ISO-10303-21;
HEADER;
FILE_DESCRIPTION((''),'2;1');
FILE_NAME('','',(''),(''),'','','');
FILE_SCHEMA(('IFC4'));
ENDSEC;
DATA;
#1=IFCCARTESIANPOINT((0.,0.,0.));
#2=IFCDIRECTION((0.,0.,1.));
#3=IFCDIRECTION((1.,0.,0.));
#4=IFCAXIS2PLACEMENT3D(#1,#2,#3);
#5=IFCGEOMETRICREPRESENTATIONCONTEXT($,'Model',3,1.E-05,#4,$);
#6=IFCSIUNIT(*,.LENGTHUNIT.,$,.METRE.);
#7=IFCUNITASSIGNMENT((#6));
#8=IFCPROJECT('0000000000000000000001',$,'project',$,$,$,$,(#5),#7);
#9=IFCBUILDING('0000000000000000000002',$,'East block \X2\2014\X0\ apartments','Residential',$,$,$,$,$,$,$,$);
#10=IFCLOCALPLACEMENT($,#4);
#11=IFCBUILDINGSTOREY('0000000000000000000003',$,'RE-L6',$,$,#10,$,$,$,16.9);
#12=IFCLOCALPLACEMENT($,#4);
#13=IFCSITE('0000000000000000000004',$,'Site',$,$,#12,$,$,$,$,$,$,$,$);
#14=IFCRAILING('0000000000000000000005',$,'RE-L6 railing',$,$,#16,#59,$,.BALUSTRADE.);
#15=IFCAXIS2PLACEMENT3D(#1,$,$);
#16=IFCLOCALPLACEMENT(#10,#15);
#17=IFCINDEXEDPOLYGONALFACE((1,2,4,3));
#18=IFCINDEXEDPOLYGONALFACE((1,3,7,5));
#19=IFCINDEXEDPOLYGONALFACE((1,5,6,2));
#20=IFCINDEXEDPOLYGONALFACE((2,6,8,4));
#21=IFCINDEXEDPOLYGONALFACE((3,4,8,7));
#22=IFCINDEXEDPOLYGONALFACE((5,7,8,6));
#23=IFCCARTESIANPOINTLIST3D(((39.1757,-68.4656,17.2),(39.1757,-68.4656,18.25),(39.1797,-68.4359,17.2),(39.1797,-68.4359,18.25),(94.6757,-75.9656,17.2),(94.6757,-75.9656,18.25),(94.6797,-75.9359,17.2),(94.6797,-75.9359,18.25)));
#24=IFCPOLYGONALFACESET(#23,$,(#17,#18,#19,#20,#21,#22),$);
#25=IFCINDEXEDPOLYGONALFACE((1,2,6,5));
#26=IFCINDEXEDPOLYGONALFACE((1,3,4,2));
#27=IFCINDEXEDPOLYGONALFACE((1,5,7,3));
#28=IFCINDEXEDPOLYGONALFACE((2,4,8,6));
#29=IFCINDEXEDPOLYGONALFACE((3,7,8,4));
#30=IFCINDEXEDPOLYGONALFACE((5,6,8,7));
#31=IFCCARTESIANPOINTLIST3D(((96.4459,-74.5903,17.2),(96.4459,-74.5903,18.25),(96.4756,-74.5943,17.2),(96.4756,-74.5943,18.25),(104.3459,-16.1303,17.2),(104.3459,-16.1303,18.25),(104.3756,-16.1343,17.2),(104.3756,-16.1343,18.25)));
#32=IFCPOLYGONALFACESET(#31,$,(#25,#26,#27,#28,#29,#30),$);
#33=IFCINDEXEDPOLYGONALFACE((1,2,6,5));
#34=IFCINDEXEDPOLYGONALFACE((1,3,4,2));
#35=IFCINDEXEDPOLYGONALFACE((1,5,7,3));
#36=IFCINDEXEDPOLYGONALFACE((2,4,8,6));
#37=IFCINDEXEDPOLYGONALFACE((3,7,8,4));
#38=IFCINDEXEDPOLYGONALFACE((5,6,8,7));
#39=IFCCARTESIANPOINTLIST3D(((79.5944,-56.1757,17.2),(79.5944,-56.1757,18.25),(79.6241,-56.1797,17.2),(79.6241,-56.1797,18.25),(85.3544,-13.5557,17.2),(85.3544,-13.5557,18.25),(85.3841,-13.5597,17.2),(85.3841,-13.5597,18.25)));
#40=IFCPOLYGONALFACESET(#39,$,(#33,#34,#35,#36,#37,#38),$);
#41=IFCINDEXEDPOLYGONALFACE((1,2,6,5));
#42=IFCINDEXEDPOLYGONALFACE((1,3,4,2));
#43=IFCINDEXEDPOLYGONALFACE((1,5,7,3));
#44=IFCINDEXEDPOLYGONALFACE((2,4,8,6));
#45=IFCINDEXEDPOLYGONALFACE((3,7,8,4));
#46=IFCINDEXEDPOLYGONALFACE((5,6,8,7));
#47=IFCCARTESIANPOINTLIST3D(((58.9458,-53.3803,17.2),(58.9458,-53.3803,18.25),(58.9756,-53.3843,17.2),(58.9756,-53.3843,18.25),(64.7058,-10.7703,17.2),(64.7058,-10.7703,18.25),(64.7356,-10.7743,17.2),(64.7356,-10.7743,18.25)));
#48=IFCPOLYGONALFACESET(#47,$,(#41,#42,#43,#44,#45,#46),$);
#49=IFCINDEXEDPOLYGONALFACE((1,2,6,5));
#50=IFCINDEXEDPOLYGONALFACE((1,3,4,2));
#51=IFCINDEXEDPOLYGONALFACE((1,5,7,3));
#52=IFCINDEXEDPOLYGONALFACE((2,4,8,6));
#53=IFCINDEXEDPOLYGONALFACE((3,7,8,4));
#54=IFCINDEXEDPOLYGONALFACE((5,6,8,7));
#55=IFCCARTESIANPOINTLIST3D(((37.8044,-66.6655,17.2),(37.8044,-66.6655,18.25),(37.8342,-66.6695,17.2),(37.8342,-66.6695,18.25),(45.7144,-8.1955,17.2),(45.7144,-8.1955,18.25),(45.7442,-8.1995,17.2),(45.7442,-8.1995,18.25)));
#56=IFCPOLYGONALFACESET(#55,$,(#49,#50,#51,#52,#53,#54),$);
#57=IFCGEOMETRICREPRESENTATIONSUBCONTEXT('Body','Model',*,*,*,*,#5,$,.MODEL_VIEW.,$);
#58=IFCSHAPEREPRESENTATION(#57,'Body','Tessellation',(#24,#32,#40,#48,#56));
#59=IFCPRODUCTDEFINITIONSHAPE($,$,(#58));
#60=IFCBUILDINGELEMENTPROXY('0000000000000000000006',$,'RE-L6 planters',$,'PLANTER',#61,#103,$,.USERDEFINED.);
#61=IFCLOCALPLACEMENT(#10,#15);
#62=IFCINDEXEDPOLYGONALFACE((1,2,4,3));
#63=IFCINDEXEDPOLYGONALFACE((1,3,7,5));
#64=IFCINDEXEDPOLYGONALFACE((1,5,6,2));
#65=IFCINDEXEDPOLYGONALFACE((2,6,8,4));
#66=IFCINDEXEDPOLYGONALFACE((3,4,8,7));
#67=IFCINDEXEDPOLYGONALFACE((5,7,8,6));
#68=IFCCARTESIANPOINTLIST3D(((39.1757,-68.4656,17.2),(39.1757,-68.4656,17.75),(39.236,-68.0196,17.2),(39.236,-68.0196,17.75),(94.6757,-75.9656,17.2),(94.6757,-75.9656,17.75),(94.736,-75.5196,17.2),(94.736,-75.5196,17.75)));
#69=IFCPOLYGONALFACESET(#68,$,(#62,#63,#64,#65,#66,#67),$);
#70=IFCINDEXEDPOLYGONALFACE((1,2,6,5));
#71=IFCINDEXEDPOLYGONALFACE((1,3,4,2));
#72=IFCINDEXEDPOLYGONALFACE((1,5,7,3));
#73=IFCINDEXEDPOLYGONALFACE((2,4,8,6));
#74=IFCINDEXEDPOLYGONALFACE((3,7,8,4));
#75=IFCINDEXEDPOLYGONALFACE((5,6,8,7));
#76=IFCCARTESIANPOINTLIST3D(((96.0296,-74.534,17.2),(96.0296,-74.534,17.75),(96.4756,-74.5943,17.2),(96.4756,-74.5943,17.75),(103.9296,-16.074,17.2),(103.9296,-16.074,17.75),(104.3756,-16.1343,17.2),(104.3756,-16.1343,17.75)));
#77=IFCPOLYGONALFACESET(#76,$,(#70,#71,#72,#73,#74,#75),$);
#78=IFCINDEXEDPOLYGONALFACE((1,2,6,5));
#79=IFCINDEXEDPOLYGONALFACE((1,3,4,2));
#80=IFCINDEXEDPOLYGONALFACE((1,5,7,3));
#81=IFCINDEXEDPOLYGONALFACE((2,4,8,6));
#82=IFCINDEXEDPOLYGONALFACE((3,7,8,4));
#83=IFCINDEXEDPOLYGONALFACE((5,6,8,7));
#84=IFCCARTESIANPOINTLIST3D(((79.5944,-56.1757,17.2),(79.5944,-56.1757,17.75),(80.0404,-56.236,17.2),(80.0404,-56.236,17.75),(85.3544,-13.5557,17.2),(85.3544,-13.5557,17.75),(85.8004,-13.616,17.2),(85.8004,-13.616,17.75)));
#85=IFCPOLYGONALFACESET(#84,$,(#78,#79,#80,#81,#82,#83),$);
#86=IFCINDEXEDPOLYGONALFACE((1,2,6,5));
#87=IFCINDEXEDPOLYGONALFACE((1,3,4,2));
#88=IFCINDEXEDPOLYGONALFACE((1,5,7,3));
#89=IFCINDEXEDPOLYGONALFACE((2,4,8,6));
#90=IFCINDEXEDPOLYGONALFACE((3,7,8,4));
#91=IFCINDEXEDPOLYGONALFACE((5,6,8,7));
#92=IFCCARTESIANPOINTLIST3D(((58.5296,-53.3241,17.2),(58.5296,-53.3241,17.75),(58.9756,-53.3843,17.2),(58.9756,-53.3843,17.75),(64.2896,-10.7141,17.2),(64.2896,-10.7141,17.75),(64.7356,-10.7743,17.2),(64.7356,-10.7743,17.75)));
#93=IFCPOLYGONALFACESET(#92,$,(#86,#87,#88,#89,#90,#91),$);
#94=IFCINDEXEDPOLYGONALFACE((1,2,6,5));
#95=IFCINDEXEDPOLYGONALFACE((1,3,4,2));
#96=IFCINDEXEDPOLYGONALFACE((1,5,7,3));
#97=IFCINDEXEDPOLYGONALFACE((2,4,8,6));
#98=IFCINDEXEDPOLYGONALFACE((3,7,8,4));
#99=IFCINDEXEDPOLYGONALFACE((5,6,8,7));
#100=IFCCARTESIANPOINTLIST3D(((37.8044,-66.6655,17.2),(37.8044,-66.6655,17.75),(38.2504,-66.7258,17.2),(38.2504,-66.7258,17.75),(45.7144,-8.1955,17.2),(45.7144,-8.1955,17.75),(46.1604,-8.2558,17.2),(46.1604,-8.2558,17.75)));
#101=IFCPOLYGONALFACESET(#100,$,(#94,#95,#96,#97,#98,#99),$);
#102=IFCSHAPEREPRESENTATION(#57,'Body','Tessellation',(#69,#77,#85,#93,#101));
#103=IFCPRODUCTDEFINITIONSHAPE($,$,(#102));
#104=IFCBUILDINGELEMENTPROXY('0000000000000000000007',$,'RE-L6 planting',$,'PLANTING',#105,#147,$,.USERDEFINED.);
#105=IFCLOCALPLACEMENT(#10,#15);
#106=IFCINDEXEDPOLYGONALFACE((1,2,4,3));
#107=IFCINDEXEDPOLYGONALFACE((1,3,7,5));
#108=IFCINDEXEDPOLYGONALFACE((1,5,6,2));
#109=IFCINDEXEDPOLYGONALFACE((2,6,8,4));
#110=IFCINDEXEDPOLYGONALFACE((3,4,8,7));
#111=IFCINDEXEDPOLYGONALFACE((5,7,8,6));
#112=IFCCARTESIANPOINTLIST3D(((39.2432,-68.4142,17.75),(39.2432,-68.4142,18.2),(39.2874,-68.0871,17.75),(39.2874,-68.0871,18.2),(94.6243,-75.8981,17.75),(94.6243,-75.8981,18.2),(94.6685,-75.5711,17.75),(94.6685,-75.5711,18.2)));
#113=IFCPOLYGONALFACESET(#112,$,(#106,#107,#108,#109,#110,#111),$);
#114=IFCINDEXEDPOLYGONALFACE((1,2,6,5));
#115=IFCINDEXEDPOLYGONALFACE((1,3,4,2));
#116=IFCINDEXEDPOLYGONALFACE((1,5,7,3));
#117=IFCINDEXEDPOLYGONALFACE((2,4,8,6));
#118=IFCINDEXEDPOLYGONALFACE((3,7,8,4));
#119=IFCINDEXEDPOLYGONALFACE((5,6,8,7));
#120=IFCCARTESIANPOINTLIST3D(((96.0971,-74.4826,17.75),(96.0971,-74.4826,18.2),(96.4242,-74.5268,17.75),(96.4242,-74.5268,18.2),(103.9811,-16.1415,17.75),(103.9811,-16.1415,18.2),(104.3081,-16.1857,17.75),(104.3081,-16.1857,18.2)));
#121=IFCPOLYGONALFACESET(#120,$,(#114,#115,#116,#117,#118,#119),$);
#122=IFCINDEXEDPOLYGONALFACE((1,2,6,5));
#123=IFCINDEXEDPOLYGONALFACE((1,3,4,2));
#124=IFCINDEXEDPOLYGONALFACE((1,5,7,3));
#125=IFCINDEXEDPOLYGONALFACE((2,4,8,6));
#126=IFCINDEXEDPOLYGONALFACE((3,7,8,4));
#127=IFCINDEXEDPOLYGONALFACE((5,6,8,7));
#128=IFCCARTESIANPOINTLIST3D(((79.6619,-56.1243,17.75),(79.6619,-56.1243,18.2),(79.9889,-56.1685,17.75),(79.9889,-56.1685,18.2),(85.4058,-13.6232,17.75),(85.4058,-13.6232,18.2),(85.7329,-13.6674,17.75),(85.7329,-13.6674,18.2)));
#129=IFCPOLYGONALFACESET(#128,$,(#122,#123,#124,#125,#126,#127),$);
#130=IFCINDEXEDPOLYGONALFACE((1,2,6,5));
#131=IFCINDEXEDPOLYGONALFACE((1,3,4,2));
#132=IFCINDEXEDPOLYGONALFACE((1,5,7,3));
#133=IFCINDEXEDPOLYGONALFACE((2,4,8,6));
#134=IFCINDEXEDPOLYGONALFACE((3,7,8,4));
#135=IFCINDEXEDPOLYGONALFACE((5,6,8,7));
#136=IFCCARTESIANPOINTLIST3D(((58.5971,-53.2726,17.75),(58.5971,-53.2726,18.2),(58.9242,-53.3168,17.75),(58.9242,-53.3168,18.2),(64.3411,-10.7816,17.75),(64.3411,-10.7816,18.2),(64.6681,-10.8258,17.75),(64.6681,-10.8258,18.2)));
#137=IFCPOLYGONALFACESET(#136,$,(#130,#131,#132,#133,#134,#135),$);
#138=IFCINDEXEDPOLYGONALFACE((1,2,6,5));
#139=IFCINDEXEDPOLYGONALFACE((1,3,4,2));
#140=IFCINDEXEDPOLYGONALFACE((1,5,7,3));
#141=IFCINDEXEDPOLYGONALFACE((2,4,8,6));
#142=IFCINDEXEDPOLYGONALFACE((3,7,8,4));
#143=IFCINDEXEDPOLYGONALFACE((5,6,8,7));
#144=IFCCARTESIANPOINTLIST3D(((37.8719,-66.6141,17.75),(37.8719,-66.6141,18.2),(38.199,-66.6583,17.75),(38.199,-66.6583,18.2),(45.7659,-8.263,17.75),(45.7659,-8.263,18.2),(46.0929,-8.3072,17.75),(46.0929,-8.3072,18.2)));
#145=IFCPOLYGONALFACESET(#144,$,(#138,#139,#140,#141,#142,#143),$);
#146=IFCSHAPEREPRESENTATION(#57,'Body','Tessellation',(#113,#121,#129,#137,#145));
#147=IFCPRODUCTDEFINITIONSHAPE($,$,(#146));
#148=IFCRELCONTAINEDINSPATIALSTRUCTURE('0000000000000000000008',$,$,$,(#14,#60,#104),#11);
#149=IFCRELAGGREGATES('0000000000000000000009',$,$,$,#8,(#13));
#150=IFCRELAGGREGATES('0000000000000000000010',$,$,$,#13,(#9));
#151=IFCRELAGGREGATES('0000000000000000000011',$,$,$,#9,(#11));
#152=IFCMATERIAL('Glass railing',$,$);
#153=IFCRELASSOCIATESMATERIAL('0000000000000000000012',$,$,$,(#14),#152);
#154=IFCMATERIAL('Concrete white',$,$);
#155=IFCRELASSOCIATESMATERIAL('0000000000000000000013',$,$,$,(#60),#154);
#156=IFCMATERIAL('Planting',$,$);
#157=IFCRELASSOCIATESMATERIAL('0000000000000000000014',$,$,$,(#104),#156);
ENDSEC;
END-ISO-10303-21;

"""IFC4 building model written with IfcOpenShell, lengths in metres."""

from ifc_helpers import new_model, si_unit, frame, origin_with_axes, place, context, subcontext, project, spatial, polyline, outline, extrude, material, element, save


model = new_model("IFC4")

# Units and contexts
model_context = context("Model", 3, precision=1e-05, world=origin_with_axes())
body_context = subcontext(model_context, "Body", "Model", "MODEL_VIEW")
ifc_project = project(units=[si_unit("LENGTHUNIT", "METRE")], contexts=[model_context])

# Site, building, storey
site_placement = place(None, origin_with_axes())
site = spatial("IfcSite", under=ifc_project, at=site_placement, Name="Site")
building = spatial("IfcBuilding", under=site, Name="East block — apartments", Description="Residential")
storey_placement = place(None, origin_with_axes())
storey = spatial("IfcBuildingStorey", under=building, at=storey_placement, Name="RE-L6", Elevation=16.9)

# Railing
ifc_material_1 = material(Name="Glass railing")
railing_placement = place(storey_placement, origin_with_axes())
element("IfcRailing", 1, at=railing_placement, inside=storey, material=ifc_material_1, Name="RE-L6 railing", PredefinedType="BALUSTRADE", context=body_context, shape_type="SweptSolid", body=[
    extrude(outline(polyline([(39.1757, -68.4656), (94.6757, -75.9656), (94.6797, -75.9359), (39.1797, -68.4359), (39.1757, -68.4656)])), frame((0.0, 0.0, 17.2), z_axis=(0.0, 0.0, 1.0), x_axis=(1.0, 0.0, 0.0)), (0.0, 0.0, 1.0), 1.05),
    extrude(outline(polyline([(96.4756, -74.5943), (104.3756, -16.1343), (104.3459, -16.1303), (96.4459, -74.5903), (96.4756, -74.5943)])), frame((0.0, 0.0, 17.2), z_axis=(0.0, 0.0, 1.0), x_axis=(1.0, 0.0, 0.0)), (0.0, 0.0, 1.0), 1.05),
    extrude(outline(polyline([(85.3544, -13.5557), (79.5944, -56.1757), (79.6241, -56.1797), (85.3841, -13.5597), (85.3544, -13.5557)])), frame((0.0, 0.0, 17.2), z_axis=(0.0, 0.0, 1.0), x_axis=(1.0, 0.0, 0.0)), (0.0, 0.0, 1.0), 1.05),
    extrude(outline(polyline([(58.9756, -53.3843), (64.7356, -10.7743), (64.7058, -10.7703), (58.9458, -53.3803), (58.9756, -53.3843)])), frame((0.0, 0.0, 17.2), z_axis=(0.0, 0.0, 1.0), x_axis=(1.0, 0.0, 0.0)), (0.0, 0.0, 1.0), 1.05),
    extrude(outline(polyline([(45.7144, -8.1955), (37.8044, -66.6655), (37.8342, -66.6695), (45.7442, -8.1995), (45.7144, -8.1955)])), frame((0.0, 0.0, 17.2), z_axis=(0.0, 0.0, 1.0), x_axis=(1.0, 0.0, 0.0)), (0.0, 0.0, 1.0), 1.05),
])

# Building element proxies
ifc_material_2 = material(Name="Concrete white")
proxy_1_placement = place(storey_placement, origin_with_axes())
element("IfcBuildingElementProxy", 2, at=proxy_1_placement, inside=storey, material=ifc_material_2, Name="RE-L6 planters", ObjectType="PLANTER", PredefinedType="USERDEFINED", context=body_context, shape_type="SweptSolid", body=[
    extrude(outline(polyline([(39.1757, -68.4656), (94.6757, -75.9656), (94.736, -75.5196), (39.236, -68.0196), (39.1757, -68.4656)])), frame((0.0, 0.0, 17.2), z_axis=(0.0, 0.0, 1.0), x_axis=(1.0, 0.0, 0.0)), (0.0, 0.0, 1.0), 0.55),
    extrude(outline(polyline([(96.4756, -74.5943), (104.3756, -16.1343), (103.9296, -16.074), (96.0296, -74.534), (96.4756, -74.5943)])), frame((0.0, 0.0, 17.2), z_axis=(0.0, 0.0, 1.0), x_axis=(1.0, 0.0, 0.0)), (0.0, 0.0, 1.0), 0.55),
    extrude(outline(polyline([(85.3544, -13.5557), (79.5944, -56.1757), (80.0404, -56.236), (85.8004, -13.616), (85.3544, -13.5557)])), frame((0.0, 0.0, 17.2), z_axis=(0.0, 0.0, 1.0), x_axis=(1.0, 0.0, 0.0)), (0.0, 0.0, 1.0), 0.55),
    extrude(outline(polyline([(58.9756, -53.3843), (64.7356, -10.7743), (64.2896, -10.7141), (58.5296, -53.3241), (58.9756, -53.3843)])), frame((0.0, 0.0, 17.2), z_axis=(0.0, 0.0, 1.0), x_axis=(1.0, 0.0, 0.0)), (0.0, 0.0, 1.0), 0.55),
    extrude(outline(polyline([(45.7144, -8.1955), (37.8044, -66.6655), (38.2504, -66.7258), (46.1604, -8.2558), (45.7144, -8.1955)])), frame((0.0, 0.0, 17.2), z_axis=(0.0, 0.0, 1.0), x_axis=(1.0, 0.0, 0.0)), (0.0, 0.0, 1.0), 0.55),
])
ifc_material_3 = material(Name="Planting")
proxy_2_placement = place(storey_placement, origin_with_axes())
element("IfcBuildingElementProxy", 3, at=proxy_2_placement, inside=storey, material=ifc_material_3, Name="RE-L6 planting", ObjectType="PLANTING", PredefinedType="USERDEFINED", context=body_context, shape_type="SweptSolid", body=[
    extrude(outline(polyline([(39.2432, -68.4142), (94.6243, -75.8981), (94.6685, -75.5711), (39.2874, -68.0871), (39.2432, -68.4142)])), frame((0.0, 0.0, 17.75), z_axis=(0.0, 0.0, 1.0), x_axis=(1.0, 0.0, 0.0)), (0.0, 0.0, 1.0), 0.45),
    extrude(outline(polyline([(96.4242, -74.5268), (104.3081, -16.1857), (103.9811, -16.1415), (96.0971, -74.4826), (96.4242, -74.5268)])), frame((0.0, 0.0, 17.75), z_axis=(0.0, 0.0, 1.0), x_axis=(1.0, 0.0, 0.0)), (0.0, 0.0, 1.0), 0.45),
    extrude(outline(polyline([(85.4058, -13.6232), (79.6619, -56.1243), (79.9889, -56.1685), (85.7329, -13.6674), (85.4058, -13.6232)])), frame((0.0, 0.0, 17.75), z_axis=(0.0, 0.0, 1.0), x_axis=(1.0, 0.0, 0.0)), (0.0, 0.0, 1.0), 0.45),
    extrude(outline(polyline([(58.9242, -53.3168), (64.6681, -10.8258), (64.3411, -10.7816), (58.5971, -53.2726), (58.9242, -53.3168)])), frame((0.0, 0.0, 17.75), z_axis=(0.0, 0.0, 1.0), x_axis=(1.0, 0.0, 0.0)), (0.0, 0.0, 1.0), 0.45),
    extrude(outline(polyline([(45.7659, -8.263), (37.8719, -66.6141), (38.199, -66.6583), (46.0929, -8.3072), (45.7659, -8.263)])), frame((0.0, 0.0, 17.75), z_axis=(0.0, 0.0, 1.0), x_axis=(1.0, 0.0, 0.0)), (0.0, 0.0, 1.0), 0.45),
])

save(model, "model.ifc")
